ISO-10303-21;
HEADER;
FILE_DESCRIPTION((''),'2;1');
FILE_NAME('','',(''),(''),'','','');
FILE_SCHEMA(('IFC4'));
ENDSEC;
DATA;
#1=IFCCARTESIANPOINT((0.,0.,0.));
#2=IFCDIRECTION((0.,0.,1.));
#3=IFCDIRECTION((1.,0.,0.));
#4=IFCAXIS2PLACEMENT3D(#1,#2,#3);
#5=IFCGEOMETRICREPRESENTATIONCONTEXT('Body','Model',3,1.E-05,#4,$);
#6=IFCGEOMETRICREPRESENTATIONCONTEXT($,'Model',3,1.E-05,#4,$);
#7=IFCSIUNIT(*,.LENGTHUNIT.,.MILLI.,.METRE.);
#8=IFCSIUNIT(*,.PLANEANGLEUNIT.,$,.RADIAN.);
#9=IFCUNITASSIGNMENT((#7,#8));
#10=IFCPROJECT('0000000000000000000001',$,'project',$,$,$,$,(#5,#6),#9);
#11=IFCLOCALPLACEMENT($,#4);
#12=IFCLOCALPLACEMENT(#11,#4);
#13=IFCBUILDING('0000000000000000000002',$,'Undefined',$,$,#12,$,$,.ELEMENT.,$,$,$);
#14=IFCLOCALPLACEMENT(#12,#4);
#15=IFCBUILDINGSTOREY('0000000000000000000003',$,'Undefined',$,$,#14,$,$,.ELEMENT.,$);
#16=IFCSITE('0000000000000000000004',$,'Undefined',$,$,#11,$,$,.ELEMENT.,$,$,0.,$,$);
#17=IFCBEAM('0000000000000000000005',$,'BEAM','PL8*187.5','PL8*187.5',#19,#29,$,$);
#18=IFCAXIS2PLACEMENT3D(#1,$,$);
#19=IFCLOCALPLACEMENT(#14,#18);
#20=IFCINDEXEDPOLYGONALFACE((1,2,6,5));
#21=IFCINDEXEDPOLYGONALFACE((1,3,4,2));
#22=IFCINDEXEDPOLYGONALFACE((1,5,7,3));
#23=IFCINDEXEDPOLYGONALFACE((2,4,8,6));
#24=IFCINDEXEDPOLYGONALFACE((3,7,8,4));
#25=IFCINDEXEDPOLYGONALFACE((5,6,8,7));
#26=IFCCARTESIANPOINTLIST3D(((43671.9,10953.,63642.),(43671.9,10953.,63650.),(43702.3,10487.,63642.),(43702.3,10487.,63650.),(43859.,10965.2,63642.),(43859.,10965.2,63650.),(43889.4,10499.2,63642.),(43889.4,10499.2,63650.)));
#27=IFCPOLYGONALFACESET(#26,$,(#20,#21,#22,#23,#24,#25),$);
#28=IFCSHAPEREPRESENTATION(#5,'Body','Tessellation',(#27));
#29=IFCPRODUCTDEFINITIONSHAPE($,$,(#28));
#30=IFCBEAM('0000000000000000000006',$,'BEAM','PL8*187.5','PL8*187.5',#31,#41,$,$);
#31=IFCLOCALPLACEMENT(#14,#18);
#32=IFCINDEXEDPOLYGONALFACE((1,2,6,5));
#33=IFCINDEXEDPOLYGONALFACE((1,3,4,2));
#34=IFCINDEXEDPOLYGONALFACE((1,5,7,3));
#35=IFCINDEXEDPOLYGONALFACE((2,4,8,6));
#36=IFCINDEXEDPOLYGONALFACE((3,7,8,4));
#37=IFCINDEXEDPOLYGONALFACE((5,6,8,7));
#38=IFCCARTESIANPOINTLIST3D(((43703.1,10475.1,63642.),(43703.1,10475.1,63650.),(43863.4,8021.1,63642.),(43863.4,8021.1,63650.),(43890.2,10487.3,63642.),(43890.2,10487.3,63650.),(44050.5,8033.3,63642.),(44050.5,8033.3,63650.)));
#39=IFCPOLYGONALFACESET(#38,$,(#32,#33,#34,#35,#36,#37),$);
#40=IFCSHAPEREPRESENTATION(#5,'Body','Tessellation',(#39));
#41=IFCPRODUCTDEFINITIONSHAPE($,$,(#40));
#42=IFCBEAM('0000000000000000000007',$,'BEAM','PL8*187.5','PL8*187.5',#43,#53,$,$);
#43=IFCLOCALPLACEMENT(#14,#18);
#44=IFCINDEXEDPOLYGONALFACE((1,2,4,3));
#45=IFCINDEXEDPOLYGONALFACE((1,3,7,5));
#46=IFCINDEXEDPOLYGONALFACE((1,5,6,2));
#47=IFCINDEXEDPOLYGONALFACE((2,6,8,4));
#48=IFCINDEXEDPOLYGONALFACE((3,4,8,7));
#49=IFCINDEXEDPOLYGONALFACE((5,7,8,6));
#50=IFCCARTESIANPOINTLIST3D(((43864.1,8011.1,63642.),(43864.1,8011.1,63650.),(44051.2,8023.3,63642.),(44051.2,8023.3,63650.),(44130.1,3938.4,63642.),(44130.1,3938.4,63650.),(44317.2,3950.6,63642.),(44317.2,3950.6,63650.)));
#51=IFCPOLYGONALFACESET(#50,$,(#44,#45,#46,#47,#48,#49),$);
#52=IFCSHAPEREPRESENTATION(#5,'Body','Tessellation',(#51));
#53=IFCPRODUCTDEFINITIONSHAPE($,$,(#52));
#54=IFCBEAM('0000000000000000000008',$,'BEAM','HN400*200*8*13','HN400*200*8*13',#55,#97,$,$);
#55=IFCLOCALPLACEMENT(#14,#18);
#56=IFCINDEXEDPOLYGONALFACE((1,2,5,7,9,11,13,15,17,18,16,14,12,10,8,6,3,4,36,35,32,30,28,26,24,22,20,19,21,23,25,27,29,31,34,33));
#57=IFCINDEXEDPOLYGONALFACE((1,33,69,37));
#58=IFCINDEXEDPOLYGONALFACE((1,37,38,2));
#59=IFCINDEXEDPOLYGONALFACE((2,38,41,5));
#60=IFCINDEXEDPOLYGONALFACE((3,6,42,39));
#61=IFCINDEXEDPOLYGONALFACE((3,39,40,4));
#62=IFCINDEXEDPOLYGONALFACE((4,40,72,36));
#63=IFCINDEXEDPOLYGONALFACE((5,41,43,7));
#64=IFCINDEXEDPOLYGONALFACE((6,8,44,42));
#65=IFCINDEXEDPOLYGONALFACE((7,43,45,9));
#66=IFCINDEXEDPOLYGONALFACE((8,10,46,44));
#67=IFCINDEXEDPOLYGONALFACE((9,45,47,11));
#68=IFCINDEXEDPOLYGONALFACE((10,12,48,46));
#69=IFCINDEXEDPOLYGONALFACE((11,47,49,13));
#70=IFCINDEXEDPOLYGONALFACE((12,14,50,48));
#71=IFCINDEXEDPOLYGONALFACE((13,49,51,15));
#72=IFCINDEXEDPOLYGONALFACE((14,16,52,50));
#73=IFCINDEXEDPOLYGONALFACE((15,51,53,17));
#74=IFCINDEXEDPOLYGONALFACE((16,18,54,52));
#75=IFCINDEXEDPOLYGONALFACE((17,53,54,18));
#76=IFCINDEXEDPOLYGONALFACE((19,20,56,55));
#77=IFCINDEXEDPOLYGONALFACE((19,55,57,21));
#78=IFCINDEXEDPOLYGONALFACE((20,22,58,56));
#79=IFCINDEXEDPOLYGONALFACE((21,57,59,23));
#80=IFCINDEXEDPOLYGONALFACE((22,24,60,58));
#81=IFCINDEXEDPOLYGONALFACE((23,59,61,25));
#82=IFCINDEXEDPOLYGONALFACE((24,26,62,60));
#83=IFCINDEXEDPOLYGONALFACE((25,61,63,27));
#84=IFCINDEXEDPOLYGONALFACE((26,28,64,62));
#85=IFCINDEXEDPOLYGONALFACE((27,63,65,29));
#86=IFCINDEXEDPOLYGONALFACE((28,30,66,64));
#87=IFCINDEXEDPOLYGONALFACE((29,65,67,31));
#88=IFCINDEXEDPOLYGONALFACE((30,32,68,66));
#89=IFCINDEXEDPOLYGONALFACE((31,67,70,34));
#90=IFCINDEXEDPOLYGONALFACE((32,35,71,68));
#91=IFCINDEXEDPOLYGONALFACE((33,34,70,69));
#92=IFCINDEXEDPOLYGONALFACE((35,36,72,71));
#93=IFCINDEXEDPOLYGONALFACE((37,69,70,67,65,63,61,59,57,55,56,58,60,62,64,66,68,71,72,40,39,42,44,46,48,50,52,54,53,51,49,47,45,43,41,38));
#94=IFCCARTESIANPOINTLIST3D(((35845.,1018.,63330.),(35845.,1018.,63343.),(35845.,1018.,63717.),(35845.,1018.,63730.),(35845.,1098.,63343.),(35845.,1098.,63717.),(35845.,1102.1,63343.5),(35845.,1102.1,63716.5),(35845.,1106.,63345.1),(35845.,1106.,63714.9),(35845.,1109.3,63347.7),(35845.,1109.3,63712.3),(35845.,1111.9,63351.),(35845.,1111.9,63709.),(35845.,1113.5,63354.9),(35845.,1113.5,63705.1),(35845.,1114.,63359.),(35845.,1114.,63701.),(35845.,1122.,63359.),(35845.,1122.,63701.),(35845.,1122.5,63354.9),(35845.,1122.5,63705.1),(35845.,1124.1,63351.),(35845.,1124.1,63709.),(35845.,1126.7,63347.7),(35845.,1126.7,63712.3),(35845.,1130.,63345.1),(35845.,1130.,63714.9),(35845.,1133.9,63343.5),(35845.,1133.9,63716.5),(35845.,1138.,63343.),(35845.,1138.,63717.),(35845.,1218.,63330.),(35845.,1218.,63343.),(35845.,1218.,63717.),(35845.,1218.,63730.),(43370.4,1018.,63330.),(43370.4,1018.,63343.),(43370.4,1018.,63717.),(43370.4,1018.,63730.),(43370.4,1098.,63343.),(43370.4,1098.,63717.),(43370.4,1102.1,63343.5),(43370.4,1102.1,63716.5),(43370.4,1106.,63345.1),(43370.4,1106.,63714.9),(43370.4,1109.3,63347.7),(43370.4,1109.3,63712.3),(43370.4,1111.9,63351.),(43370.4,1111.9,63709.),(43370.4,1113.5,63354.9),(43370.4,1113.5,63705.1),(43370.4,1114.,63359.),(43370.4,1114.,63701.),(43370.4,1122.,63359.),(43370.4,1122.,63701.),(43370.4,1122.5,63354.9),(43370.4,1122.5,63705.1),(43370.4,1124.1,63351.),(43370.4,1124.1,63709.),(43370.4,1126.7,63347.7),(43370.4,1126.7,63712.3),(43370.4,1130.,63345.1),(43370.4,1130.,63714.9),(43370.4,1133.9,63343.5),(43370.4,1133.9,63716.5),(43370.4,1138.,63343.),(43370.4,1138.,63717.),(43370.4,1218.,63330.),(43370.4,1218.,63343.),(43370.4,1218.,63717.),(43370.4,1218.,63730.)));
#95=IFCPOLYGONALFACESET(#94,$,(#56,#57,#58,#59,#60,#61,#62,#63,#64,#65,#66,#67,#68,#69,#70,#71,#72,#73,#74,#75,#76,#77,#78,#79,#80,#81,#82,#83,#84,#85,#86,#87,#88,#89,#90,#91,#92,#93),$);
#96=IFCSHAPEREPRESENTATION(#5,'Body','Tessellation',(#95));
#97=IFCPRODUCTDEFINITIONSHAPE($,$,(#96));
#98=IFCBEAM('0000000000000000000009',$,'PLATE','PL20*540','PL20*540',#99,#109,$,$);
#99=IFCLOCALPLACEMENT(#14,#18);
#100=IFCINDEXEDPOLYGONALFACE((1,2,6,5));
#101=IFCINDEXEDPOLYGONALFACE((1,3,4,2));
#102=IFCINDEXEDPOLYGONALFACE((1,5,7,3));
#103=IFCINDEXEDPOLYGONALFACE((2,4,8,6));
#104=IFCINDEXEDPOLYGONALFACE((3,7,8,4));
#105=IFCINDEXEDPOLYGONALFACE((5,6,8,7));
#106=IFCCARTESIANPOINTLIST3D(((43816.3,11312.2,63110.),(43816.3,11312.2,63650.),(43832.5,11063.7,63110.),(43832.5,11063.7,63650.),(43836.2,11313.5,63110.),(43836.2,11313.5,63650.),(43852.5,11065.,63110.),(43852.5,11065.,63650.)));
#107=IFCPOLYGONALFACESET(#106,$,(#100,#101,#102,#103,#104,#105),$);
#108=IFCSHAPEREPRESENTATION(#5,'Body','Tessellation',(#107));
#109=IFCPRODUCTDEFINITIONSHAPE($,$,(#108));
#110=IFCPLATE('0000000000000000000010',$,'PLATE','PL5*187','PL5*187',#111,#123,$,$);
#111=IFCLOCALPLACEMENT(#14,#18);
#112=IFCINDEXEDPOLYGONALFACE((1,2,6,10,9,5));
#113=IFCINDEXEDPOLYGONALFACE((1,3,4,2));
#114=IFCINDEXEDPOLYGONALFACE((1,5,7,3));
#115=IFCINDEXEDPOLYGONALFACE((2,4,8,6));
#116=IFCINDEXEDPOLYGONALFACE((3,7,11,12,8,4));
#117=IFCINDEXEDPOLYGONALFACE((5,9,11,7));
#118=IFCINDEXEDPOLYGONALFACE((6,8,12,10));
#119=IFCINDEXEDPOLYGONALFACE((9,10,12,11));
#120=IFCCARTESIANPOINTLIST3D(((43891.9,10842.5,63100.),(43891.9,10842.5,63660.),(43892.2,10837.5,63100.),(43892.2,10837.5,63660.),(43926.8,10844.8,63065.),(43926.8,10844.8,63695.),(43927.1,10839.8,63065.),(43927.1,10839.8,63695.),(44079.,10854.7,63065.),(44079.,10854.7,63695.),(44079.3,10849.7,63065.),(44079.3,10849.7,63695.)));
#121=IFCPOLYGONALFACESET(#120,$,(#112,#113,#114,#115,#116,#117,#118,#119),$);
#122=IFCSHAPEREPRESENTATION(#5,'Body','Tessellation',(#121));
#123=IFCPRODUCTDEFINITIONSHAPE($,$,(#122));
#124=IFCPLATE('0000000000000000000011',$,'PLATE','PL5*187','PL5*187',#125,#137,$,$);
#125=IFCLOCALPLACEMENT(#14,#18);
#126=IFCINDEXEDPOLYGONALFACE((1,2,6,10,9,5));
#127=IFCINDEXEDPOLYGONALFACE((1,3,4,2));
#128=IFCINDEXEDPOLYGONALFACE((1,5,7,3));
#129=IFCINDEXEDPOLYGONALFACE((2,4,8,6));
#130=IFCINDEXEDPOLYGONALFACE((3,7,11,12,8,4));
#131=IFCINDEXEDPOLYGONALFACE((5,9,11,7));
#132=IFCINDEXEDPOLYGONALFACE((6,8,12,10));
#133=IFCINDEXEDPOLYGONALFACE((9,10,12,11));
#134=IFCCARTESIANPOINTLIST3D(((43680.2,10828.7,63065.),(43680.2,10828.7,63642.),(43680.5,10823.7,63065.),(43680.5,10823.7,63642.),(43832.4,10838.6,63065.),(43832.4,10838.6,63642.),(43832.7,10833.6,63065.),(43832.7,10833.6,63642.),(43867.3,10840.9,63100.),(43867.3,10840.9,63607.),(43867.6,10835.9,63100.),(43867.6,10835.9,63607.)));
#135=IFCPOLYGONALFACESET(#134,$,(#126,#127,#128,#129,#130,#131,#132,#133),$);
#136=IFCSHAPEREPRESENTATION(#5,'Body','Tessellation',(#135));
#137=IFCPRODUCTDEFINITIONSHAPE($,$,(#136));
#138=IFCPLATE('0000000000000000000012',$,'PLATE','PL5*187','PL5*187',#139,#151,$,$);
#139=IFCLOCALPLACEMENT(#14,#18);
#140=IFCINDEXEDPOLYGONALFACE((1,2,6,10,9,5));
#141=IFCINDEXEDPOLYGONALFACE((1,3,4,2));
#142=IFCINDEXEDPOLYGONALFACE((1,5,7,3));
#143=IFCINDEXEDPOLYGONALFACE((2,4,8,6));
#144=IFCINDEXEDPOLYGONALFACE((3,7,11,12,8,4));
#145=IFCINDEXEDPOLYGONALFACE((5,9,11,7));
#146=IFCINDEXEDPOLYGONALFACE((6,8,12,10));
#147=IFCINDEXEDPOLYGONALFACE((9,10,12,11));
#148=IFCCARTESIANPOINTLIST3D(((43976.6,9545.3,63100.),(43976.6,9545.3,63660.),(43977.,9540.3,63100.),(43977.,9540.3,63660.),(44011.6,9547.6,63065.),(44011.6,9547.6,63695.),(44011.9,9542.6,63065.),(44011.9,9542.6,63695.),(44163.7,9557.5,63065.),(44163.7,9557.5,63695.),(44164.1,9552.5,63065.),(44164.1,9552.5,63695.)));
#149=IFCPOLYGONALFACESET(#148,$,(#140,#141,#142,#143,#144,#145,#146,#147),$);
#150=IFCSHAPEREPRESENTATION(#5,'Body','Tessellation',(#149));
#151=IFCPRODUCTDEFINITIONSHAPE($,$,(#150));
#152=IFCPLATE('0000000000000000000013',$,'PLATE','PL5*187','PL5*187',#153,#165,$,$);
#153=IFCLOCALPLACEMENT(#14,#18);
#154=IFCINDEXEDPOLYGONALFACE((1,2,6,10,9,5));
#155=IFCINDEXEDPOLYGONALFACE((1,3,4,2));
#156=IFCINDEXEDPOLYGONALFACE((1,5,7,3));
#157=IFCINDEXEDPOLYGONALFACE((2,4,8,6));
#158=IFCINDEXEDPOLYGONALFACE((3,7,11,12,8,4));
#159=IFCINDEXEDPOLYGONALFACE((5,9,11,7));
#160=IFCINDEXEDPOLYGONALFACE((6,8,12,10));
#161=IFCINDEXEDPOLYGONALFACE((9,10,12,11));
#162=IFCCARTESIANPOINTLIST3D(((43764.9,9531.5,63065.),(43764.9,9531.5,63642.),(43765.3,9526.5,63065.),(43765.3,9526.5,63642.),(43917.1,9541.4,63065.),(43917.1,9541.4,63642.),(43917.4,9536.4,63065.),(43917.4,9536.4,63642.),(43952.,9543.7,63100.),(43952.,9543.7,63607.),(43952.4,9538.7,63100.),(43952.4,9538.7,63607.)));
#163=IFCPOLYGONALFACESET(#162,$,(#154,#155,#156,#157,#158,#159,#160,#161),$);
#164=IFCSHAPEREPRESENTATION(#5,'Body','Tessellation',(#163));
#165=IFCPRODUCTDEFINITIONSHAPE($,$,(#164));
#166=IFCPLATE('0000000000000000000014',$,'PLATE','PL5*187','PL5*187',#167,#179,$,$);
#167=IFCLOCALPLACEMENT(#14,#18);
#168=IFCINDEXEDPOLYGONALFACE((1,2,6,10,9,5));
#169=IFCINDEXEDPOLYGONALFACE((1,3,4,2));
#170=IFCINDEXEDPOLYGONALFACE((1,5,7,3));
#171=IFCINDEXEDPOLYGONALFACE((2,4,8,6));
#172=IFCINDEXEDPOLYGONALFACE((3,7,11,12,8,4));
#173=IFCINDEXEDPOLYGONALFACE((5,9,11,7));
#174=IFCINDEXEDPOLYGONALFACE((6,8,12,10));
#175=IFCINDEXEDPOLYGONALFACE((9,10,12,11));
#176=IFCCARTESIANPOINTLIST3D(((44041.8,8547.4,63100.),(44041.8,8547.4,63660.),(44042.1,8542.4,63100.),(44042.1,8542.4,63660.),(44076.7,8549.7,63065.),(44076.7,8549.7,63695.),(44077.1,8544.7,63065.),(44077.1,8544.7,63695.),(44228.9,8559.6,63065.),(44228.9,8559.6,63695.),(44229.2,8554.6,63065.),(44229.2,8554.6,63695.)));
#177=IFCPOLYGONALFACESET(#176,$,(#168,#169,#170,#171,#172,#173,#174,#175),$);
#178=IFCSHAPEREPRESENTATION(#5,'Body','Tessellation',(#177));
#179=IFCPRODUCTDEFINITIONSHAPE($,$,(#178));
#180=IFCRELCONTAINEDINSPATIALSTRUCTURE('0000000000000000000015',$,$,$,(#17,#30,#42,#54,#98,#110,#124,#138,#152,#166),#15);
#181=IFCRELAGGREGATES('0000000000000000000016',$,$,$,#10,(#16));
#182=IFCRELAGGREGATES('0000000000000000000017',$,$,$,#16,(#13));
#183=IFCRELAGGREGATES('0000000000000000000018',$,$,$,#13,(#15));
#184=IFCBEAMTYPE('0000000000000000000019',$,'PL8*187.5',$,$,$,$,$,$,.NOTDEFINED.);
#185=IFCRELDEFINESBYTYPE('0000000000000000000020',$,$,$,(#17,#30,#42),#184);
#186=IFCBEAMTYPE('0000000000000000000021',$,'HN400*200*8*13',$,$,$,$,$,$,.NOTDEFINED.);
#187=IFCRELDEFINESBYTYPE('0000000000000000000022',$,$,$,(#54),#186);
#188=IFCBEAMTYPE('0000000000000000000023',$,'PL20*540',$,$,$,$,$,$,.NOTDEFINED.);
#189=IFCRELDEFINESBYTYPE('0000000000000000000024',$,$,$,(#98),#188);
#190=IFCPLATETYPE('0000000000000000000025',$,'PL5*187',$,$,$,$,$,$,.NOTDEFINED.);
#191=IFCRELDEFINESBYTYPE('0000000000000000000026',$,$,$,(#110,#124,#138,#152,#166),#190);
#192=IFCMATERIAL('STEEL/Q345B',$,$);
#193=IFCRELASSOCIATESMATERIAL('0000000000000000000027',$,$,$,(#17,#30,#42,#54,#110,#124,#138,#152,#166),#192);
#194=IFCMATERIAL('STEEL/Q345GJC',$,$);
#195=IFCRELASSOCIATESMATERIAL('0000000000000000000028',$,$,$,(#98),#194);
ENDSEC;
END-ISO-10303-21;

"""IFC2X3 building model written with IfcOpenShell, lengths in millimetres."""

from ifc_helpers import new_model, si_unit, frame, origin_with_axes, origin_2d_with_axis, place, context, project, spatial, polyline, rectangle, i_section, outline, extrude, material, type_object, element, save


model = new_model("IFC2X3")

# Units and contexts
model_context_1 = context("Model", 3, precision=1e-05, world=origin_with_axes(), identifier="Body")
model_context_2 = context("Model", 3, precision=1e-05, world=origin_with_axes())
ifc_project = project(units=[si_unit("LENGTHUNIT", "METRE", prefix="MILLI"), si_unit("PLANEANGLEUNIT", "RADIAN")], contexts=[model_context_1, model_context_2])

# Site, building, storey
site_placement = place(None, origin_with_axes())
site = spatial("IfcSite", under=ifc_project, at=site_placement, Name="Undefined", CompositionType="ELEMENT", RefElevation=0.0)
building_placement = place(site_placement, origin_with_axes())
building = spatial("IfcBuilding", under=site, at=building_placement, Name="Undefined", CompositionType="ELEMENT")
storey_placement = place(building_placement, origin_with_axes())
storey = spatial("IfcBuildingStorey", under=building, at=storey_placement, Name="Undefined", CompositionType="ELEMENT")

# Beams
ifc_material_1 = material(Name="STEEL/Q345B")
beam_type_1 = type_object("IfcBeamType", Name="PL8*187.5", PredefinedType="NOTDEFINED")
beam_1_placement = place(storey_placement, frame((43795.9, 10493.1, 63646.0), z_axis=(0.997873, 0.065184, 0.0), x_axis=(-0.065184, 0.997873, 0.0)))
element("IfcBeam", 1, at=beam_1_placement, inside=storey, type_object=beam_type_1, material=ifc_material_1, Name="BEAM", Description="PL8*187.5", ObjectType="PL8*187.5", context=model_context_1, shape_type="SweptSolid", body=[
    extrude(rectangle(XDim=8.0, YDim=187.5, at=origin_2d_with_axis()), frame((466.9, 0.0, 0.0), z_axis=(-1.0, 0.0, 0.0), x_axis=(0.0, -1.0, 0.0)), (0.0, 0.0, 1.0), 466.9),
])
beam_2_placement = place(storey_placement, frame((43957.0, 8027.2, 63646.0), z_axis=(0.997873, 0.065184, 0.0), x_axis=(-0.065184, 0.997873, 0.0)))
element("IfcBeam", 2, at=beam_2_placement, inside=storey, type_object=beam_type_1, material=ifc_material_1, Name="BEAM", Description="PL8*187.5", ObjectType="PL8*187.5", context=model_context_1, shape_type="SweptSolid", body=[
    extrude(rectangle(XDim=8.0, YDim=187.5, at=origin_2d_with_axis()), frame((2459.2, 0.0, 0.0), z_axis=(-1.0, 0.0, 0.0), x_axis=(0.0, -1.0, 0.0)), (0.0, 0.0, 1.0), 2459.2),
])
beam_3_placement = place(storey_placement, frame((44223.6, 3944.5, 63646.0), z_axis=(0.997873, 0.065184, 0.0), x_axis=(-0.065184, 0.997873, 0.0)))
element("IfcBeam", 3, at=beam_3_placement, inside=storey, type_object=beam_type_1, material=ifc_material_1, Name="BEAM", Description="PL8*187.5", ObjectType="PL8*187.5", context=model_context_1, shape_type="SweptSolid", body=[
    extrude(rectangle(XDim=8.0, YDim=187.5, at=origin_2d_with_axis()), frame((4081.3, 0.0, 0.0), z_axis=(-1.0, 0.0, 0.0), x_axis=(0.0, -1.0, 0.0)), (0.0, 0.0, 1.0), 4081.3),
])
beam_type_2 = type_object("IfcBeamType", Name="HN400*200*8*13", PredefinedType="NOTDEFINED")
beam_4_placement = place(storey_placement, frame((44321.8, 1118.0, 63530.0), z_axis=(0.0, 0.0, 1.0), x_axis=(-1.0, 0.0, 0.0)))
element("IfcBeam", 4, at=beam_4_placement, inside=storey, type_object=beam_type_2, material=ifc_material_1, Name="BEAM", Description="HN400*200*8*13", ObjectType="HN400*200*8*13", context=model_context_1, shape_type="SweptSolid", body=[
    extrude(i_section(OverallWidth=200.0, OverallDepth=400.0, WebThickness=8.0, FlangeThickness=13.0, FilletRadius=16.0, at=origin_2d_with_axis()), frame((8476.8, 0.0, 0.0), z_axis=(-1.0, 0.0, 0.0), x_axis=(0.0, -1.0, 0.0)), (0.0, 0.0, 1.0), 7525.4),
])
ifc_material_2 = material(Name="STEEL/Q345GJC")
beam_type_3 = type_object("IfcBeamType", Name="PL20*540", PredefinedType="NOTDEFINED")
beam_5_placement = place(storey_placement, frame((43826.3, 11312.8, 63380.0), z_axis=(0.0, 0.0, 1.0), x_axis=(0.065183, -0.997873, 0.0)))
element("IfcBeam", 5, at=beam_5_placement, inside=storey, type_object=beam_type_3, material=ifc_material_2, Name="PLATE", Description="PL20*540", ObjectType="PL20*540", context=model_context_1, shape_type="SweptSolid", body=[
    extrude(rectangle(XDim=20.0, YDim=540.0, at=origin_2d_with_axis()), frame((249.0, 0.0, 0.0), z_axis=(-1.0, 0.0, 0.0), x_axis=(0.0, -1.0, 0.0)), (0.0, 0.0, 1.0), 249.0),
])

# Plates
plate_type_1 = type_object("IfcPlateType", Name="PL5*187", PredefinedType="NOTDEFINED")
plate_1_placement = place(storey_placement, frame((44079.2, 10852.2, 63695.0), z_axis=(0.065171, -0.997874, 0.0), x_axis=(-0.997874, -0.065171, 0.0)))
element("IfcPlate", 6, at=plate_1_placement, inside=storey, type_object=plate_type_1, material=ifc_material_1, Name="PLATE", Description="PL5*187", ObjectType="PL5*187", context=model_context_1, shape_type="SweptSolid", body=[
    extrude(outline(polyline([(0.0, 0.0), (152.5, 0.0), (187.5, 35.0), (187.5, 595.0), (152.5, 630.0), (0.0, 630.0), (0.0, 0.0)])), frame((0.0, 0.0, -2.5), z_axis=(0.0, 0.0, 1.0), x_axis=(1.0, 0.0, 0.0)), (0.0, 0.0, 1.0), 5.0),
])
plate_2_placement = place(storey_placement, frame((43680.4, 10826.2, 63642.0), z_axis=(-0.065184, 0.997873, 0.0), x_axis=(0.997873, 0.065184, 0.0)))
element("IfcPlate", 7, at=plate_2_placement, inside=storey, type_object=plate_type_1, material=ifc_material_1, Name="PLATE", Description="PL5*187", ObjectType="PL5*187", context=model_context_1, shape_type="SweptSolid", body=[
    extrude(outline(polyline([(0.0, 0.0), (152.5, 0.0), (187.5, 35.0), (187.5, 542.0), (152.5, 577.0), (0.0, 577.0), (0.0, 0.0)])), frame((0.0, 0.0, -2.5), z_axis=(0.0, 0.0, 1.0), x_axis=(1.0, 0.0, 0.0)), (0.0, 0.0, 1.0), 5.0),
])
plate_3_placement = place(storey_placement, frame((44163.9, 9555.0, 63695.0), z_axis=(0.065171, -0.997874, 0.0), x_axis=(-0.997874, -0.065171, 0.0)))
element("IfcPlate", 8, at=plate_3_placement, inside=storey, type_object=plate_type_1, material=ifc_material_1, Name="PLATE", Description="PL5*187", ObjectType="PL5*187", context=model_context_1, shape_type="SweptSolid", body=[
    extrude(outline(polyline([(0.0, 0.0), (152.5, 0.0), (187.5, 35.0), (187.5, 595.0), (152.5, 630.0), (0.0, 630.0), (0.0, 0.0)])), frame((0.0, 0.0, -2.5), z_axis=(0.0, 0.0, 1.0), x_axis=(1.0, 0.0, 0.0)), (0.0, 0.0, 1.0), 5.0),
])
plate_4_placement = place(storey_placement, frame((43765.1, 9529.0, 63642.0), z_axis=(-0.065184, 0.997873, 0.0), x_axis=(0.997873, 0.065184, 0.0)))
element("IfcPlate", 9, at=plate_4_placement, inside=storey, type_object=plate_type_1, material=ifc_material_1, Name="PLATE", Description="PL5*187", ObjectType="PL5*187", context=model_context_1, shape_type="SweptSolid", body=[
    extrude(outline(polyline([(0.0, 0.0), (152.5, 0.0), (187.5, 35.0), (187.5, 542.0), (152.5, 577.0), (0.0, 577.0), (0.0, 0.0)])), frame((0.0, 0.0, -2.5), z_axis=(0.0, 0.0, 1.0), x_axis=(1.0, 0.0, 0.0)), (0.0, 0.0, 1.0), 5.0),
])
plate_5_placement = place(storey_placement, frame((44229.1, 8557.1, 63695.0), z_axis=(0.065171, -0.997874, 0.0), x_axis=(-0.997874, -0.065171, 0.0)))
element("IfcPlate", 10, at=plate_5_placement, inside=storey, type_object=plate_type_1, material=ifc_material_1, Name="PLATE", Description="PL5*187", ObjectType="PL5*187", context=model_context_1, shape_type="SweptSolid", body=[
    extrude(outline(polyline([(0.0, 0.0), (152.5, 0.0), (187.5, 35.0), (187.5, 595.0), (152.5, 630.0), (0.0, 630.0), (0.0, 0.0)])), frame((0.0, 0.0, -2.5), z_axis=(0.0, 0.0, 1.0), x_axis=(1.0, 0.0, 0.0)), (0.0, 0.0, 1.0), 5.0),
])

save(model, "model.ifc")
